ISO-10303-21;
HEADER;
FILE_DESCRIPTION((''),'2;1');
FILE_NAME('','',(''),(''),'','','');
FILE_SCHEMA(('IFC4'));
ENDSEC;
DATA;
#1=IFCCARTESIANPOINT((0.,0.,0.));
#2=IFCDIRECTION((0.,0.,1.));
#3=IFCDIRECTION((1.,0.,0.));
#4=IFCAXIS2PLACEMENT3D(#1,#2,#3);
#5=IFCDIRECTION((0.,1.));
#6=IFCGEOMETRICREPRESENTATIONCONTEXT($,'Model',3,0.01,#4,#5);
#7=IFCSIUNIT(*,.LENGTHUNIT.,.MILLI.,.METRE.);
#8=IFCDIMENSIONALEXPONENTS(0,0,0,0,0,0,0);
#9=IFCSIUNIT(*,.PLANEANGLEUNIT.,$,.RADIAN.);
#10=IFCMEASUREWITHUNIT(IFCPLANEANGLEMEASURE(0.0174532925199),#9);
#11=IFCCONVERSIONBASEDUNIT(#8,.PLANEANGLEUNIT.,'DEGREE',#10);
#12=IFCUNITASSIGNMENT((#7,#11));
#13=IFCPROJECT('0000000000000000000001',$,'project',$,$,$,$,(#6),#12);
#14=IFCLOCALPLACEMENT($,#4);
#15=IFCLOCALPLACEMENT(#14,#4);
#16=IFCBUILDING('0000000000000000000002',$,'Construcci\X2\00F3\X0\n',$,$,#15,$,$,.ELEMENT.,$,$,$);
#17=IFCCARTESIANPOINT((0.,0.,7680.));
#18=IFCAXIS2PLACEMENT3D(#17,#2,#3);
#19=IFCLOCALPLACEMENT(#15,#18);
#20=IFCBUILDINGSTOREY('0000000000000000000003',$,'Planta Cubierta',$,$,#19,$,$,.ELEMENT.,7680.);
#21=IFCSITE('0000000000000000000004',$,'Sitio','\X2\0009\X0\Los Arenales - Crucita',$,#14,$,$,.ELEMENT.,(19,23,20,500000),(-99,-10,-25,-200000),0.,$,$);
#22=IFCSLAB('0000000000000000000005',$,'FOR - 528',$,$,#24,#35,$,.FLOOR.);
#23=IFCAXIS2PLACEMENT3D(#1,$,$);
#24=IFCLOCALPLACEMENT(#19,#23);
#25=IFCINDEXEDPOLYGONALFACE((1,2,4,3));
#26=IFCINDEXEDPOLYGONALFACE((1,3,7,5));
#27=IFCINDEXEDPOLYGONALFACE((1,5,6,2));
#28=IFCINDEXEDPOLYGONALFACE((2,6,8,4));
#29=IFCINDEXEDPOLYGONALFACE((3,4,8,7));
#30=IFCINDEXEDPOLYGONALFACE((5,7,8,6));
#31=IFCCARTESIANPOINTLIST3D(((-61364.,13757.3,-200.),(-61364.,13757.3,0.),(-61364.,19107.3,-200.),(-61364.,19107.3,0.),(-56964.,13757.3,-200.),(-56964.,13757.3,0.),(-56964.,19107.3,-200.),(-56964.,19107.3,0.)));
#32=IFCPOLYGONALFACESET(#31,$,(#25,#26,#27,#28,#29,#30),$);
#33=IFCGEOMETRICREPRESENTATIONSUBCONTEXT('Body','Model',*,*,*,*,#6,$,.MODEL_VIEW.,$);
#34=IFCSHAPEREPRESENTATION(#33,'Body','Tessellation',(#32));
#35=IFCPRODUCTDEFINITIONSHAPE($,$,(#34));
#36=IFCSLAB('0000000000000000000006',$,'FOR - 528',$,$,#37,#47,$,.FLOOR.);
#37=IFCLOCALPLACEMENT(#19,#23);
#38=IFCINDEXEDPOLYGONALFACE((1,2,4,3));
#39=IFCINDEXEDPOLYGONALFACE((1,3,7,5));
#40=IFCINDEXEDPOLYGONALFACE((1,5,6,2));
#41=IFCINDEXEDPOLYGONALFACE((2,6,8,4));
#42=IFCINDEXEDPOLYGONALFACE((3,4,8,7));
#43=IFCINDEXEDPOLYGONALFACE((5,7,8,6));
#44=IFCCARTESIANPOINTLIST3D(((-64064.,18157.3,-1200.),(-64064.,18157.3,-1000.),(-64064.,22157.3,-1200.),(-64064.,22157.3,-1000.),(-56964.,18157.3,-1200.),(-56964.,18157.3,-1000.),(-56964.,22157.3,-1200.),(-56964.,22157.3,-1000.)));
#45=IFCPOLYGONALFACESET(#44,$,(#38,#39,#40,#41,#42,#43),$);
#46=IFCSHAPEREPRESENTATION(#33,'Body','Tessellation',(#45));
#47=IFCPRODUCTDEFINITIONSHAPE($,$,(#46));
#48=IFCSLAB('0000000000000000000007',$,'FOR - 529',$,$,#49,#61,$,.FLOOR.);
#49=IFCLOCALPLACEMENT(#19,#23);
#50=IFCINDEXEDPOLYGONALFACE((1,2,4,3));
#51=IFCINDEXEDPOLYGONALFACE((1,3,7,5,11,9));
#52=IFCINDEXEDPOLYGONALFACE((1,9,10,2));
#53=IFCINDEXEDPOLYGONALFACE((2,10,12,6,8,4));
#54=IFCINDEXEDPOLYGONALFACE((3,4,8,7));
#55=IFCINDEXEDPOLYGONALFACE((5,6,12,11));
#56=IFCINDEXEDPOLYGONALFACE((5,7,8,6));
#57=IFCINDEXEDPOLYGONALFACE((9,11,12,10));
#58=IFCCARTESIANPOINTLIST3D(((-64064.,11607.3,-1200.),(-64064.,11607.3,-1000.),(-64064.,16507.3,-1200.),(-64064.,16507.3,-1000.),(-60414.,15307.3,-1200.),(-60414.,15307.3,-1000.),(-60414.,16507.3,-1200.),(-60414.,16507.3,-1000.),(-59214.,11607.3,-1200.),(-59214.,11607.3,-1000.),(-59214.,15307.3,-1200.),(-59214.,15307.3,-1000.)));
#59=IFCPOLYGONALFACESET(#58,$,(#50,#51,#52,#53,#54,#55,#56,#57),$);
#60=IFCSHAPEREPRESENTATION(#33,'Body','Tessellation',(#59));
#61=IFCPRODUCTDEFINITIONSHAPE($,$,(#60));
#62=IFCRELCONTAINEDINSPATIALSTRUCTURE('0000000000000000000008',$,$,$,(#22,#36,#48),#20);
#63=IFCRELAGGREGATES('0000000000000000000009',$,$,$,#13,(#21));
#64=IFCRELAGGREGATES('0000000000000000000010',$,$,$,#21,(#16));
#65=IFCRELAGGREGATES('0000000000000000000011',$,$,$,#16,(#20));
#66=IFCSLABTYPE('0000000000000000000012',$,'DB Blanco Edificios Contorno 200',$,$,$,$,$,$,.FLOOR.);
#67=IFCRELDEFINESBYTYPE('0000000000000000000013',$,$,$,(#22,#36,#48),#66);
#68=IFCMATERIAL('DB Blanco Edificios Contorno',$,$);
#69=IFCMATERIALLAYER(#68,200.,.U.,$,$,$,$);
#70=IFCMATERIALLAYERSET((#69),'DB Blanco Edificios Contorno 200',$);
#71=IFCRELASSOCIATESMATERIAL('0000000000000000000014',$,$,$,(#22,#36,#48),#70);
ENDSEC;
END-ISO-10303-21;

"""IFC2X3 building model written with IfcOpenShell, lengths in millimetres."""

from ifc_helpers import new_model, entity, si_unit, converted_unit, direction, frame, origin_with_axes, place, context, subcontext, project, spatial, polyline, outline, extrude, material, layer, layer_set, layer_usage, type_object, element, save


model = new_model("IFC2X3")

# Units and contexts
model_context = context("Model", 3, precision=0.01, world=origin_with_axes(), true_north=direction((0.0, 1.0)))
body_context = subcontext(model_context, "Body", "Model", "MODEL_VIEW")
ifc_project = project(units=[si_unit("LENGTHUNIT", "METRE", prefix="MILLI"), converted_unit("PLANEANGLEUNIT", "DEGREE", entity("IfcPlaneAngleMeasure", 0.0174532925199), si_unit("PLANEANGLEUNIT", "RADIAN"), dimensions=[0, 0, 0, 0, 0, 0, 0])], contexts=[model_context])

# Site, building, storey
site_placement = place(None, origin_with_axes())
site = spatial("IfcSite", under=ifc_project, at=site_placement, Name="Sitio", Description="\tLos Arenales - Crucita", CompositionType="ELEMENT", RefLatitude=(19, 23, 20, 500000), RefLongitude=(-99, -10, -25, -200000), RefElevation=0.0)
building_placement = place(site_placement, origin_with_axes())
building = spatial("IfcBuilding", under=site, at=building_placement, Name="Construcción", CompositionType="ELEMENT")
storey_placement = place(building_placement, frame((0.0, 0.0, 7680.0), z_axis=(0.0, 0.0, 1.0), x_axis=(1.0, 0.0, 0.0)))
storey = spatial("IfcBuildingStorey", under=building, at=storey_placement, Name="Planta Cubierta", CompositionType="ELEMENT", Elevation=7680.0)

# Slabs
ifc_material = material(Name="DB Blanco Edificios Contorno")
ifc_layer = layer(ifc_material, 200.0, ventilated="UNKNOWN")
ifc_layer_set = layer_set([ifc_layer], Name="DB Blanco Edificios Contorno 200")
ifc_layer_usage_1 = layer_usage(ifc_layer_set, "AXIS3", "NEGATIVE", 200.0)
slab_type = type_object("IfcSlabType", Name="DB Blanco Edificios Contorno 200", PredefinedType="FLOOR")
slab_1_placement = place(storey_placement, frame((-61364.0, 13757.3, 0.0), z_axis=(0.0, 0.0, 1.0), x_axis=(1.0, 0.0, 0.0)))
element("IfcSlab", 1, at=slab_1_placement, inside=storey, type_object=slab_type, material=ifc_layer_usage_1, Name="FOR - 528", PredefinedType="FLOOR", context=body_context, shape_type="SweptSolid", body=[
    extrude(outline(polyline([(0.0, 0.0), (4400.0, 0.0), (4400.0, 5350.0), (0.0, 5350.0), (0.0, 0.0)])), frame((0.0, 0.0, -200.0), z_axis=(0.0, 0.0, 1.0), x_axis=(1.0, 0.0, 0.0)), (0.0, 0.0, 1.0), 200.0),
])
ifc_layer_usage_2 = layer_usage(ifc_layer_set, "AXIS3", "NEGATIVE", 200.0)
slab_2_placement = place(storey_placement, frame((-64064.0, 18157.3, -1000.0), z_axis=(0.0, 0.0, 1.0), x_axis=(1.0, 0.0, 0.0)))
element("IfcSlab", 2, at=slab_2_placement, inside=storey, type_object=slab_type, material=ifc_layer_usage_2, Name="FOR - 528", PredefinedType="FLOOR", context=body_context, shape_type="SweptSolid", body=[
    extrude(outline(polyline([(0.0, 0.0), (7100.0, 0.0), (7100.0, 4000.0), (0.0, 4000.0), (0.0, 0.0)])), frame((0.0, 0.0, -200.0), z_axis=(0.0, 0.0, 1.0), x_axis=(1.0, 0.0, 0.0)), (0.0, 0.0, 1.0), 200.0),
])
ifc_layer_usage_3 = layer_usage(ifc_layer_set, "AXIS3", "NEGATIVE", 200.0)
slab_3_placement = place(storey_placement, frame((-64064.0, 11607.3, -1000.0), z_axis=(0.0, 0.0, 1.0), x_axis=(1.0, 0.0, 0.0)))
element("IfcSlab", 3, at=slab_3_placement, inside=storey, type_object=slab_type, material=ifc_layer_usage_3, Name="FOR - 529", PredefinedType="FLOOR", context=body_context, shape_type="SweptSolid", body=[
    extrude(outline(polyline([(0.0, 0.0), (4850.0, 0.0), (4850.0, 3700.0), (3650.0, 3700.0), (3650.0, 4900.0), (0.0, 4900.0), (0.0, 0.0)])), frame((0.0, 0.0, -200.0), z_axis=(0.0, 0.0, 1.0), x_axis=(1.0, 0.0, 0.0)), (0.0, 0.0, 1.0), 200.0),
])

save(model, "model.ifc")
